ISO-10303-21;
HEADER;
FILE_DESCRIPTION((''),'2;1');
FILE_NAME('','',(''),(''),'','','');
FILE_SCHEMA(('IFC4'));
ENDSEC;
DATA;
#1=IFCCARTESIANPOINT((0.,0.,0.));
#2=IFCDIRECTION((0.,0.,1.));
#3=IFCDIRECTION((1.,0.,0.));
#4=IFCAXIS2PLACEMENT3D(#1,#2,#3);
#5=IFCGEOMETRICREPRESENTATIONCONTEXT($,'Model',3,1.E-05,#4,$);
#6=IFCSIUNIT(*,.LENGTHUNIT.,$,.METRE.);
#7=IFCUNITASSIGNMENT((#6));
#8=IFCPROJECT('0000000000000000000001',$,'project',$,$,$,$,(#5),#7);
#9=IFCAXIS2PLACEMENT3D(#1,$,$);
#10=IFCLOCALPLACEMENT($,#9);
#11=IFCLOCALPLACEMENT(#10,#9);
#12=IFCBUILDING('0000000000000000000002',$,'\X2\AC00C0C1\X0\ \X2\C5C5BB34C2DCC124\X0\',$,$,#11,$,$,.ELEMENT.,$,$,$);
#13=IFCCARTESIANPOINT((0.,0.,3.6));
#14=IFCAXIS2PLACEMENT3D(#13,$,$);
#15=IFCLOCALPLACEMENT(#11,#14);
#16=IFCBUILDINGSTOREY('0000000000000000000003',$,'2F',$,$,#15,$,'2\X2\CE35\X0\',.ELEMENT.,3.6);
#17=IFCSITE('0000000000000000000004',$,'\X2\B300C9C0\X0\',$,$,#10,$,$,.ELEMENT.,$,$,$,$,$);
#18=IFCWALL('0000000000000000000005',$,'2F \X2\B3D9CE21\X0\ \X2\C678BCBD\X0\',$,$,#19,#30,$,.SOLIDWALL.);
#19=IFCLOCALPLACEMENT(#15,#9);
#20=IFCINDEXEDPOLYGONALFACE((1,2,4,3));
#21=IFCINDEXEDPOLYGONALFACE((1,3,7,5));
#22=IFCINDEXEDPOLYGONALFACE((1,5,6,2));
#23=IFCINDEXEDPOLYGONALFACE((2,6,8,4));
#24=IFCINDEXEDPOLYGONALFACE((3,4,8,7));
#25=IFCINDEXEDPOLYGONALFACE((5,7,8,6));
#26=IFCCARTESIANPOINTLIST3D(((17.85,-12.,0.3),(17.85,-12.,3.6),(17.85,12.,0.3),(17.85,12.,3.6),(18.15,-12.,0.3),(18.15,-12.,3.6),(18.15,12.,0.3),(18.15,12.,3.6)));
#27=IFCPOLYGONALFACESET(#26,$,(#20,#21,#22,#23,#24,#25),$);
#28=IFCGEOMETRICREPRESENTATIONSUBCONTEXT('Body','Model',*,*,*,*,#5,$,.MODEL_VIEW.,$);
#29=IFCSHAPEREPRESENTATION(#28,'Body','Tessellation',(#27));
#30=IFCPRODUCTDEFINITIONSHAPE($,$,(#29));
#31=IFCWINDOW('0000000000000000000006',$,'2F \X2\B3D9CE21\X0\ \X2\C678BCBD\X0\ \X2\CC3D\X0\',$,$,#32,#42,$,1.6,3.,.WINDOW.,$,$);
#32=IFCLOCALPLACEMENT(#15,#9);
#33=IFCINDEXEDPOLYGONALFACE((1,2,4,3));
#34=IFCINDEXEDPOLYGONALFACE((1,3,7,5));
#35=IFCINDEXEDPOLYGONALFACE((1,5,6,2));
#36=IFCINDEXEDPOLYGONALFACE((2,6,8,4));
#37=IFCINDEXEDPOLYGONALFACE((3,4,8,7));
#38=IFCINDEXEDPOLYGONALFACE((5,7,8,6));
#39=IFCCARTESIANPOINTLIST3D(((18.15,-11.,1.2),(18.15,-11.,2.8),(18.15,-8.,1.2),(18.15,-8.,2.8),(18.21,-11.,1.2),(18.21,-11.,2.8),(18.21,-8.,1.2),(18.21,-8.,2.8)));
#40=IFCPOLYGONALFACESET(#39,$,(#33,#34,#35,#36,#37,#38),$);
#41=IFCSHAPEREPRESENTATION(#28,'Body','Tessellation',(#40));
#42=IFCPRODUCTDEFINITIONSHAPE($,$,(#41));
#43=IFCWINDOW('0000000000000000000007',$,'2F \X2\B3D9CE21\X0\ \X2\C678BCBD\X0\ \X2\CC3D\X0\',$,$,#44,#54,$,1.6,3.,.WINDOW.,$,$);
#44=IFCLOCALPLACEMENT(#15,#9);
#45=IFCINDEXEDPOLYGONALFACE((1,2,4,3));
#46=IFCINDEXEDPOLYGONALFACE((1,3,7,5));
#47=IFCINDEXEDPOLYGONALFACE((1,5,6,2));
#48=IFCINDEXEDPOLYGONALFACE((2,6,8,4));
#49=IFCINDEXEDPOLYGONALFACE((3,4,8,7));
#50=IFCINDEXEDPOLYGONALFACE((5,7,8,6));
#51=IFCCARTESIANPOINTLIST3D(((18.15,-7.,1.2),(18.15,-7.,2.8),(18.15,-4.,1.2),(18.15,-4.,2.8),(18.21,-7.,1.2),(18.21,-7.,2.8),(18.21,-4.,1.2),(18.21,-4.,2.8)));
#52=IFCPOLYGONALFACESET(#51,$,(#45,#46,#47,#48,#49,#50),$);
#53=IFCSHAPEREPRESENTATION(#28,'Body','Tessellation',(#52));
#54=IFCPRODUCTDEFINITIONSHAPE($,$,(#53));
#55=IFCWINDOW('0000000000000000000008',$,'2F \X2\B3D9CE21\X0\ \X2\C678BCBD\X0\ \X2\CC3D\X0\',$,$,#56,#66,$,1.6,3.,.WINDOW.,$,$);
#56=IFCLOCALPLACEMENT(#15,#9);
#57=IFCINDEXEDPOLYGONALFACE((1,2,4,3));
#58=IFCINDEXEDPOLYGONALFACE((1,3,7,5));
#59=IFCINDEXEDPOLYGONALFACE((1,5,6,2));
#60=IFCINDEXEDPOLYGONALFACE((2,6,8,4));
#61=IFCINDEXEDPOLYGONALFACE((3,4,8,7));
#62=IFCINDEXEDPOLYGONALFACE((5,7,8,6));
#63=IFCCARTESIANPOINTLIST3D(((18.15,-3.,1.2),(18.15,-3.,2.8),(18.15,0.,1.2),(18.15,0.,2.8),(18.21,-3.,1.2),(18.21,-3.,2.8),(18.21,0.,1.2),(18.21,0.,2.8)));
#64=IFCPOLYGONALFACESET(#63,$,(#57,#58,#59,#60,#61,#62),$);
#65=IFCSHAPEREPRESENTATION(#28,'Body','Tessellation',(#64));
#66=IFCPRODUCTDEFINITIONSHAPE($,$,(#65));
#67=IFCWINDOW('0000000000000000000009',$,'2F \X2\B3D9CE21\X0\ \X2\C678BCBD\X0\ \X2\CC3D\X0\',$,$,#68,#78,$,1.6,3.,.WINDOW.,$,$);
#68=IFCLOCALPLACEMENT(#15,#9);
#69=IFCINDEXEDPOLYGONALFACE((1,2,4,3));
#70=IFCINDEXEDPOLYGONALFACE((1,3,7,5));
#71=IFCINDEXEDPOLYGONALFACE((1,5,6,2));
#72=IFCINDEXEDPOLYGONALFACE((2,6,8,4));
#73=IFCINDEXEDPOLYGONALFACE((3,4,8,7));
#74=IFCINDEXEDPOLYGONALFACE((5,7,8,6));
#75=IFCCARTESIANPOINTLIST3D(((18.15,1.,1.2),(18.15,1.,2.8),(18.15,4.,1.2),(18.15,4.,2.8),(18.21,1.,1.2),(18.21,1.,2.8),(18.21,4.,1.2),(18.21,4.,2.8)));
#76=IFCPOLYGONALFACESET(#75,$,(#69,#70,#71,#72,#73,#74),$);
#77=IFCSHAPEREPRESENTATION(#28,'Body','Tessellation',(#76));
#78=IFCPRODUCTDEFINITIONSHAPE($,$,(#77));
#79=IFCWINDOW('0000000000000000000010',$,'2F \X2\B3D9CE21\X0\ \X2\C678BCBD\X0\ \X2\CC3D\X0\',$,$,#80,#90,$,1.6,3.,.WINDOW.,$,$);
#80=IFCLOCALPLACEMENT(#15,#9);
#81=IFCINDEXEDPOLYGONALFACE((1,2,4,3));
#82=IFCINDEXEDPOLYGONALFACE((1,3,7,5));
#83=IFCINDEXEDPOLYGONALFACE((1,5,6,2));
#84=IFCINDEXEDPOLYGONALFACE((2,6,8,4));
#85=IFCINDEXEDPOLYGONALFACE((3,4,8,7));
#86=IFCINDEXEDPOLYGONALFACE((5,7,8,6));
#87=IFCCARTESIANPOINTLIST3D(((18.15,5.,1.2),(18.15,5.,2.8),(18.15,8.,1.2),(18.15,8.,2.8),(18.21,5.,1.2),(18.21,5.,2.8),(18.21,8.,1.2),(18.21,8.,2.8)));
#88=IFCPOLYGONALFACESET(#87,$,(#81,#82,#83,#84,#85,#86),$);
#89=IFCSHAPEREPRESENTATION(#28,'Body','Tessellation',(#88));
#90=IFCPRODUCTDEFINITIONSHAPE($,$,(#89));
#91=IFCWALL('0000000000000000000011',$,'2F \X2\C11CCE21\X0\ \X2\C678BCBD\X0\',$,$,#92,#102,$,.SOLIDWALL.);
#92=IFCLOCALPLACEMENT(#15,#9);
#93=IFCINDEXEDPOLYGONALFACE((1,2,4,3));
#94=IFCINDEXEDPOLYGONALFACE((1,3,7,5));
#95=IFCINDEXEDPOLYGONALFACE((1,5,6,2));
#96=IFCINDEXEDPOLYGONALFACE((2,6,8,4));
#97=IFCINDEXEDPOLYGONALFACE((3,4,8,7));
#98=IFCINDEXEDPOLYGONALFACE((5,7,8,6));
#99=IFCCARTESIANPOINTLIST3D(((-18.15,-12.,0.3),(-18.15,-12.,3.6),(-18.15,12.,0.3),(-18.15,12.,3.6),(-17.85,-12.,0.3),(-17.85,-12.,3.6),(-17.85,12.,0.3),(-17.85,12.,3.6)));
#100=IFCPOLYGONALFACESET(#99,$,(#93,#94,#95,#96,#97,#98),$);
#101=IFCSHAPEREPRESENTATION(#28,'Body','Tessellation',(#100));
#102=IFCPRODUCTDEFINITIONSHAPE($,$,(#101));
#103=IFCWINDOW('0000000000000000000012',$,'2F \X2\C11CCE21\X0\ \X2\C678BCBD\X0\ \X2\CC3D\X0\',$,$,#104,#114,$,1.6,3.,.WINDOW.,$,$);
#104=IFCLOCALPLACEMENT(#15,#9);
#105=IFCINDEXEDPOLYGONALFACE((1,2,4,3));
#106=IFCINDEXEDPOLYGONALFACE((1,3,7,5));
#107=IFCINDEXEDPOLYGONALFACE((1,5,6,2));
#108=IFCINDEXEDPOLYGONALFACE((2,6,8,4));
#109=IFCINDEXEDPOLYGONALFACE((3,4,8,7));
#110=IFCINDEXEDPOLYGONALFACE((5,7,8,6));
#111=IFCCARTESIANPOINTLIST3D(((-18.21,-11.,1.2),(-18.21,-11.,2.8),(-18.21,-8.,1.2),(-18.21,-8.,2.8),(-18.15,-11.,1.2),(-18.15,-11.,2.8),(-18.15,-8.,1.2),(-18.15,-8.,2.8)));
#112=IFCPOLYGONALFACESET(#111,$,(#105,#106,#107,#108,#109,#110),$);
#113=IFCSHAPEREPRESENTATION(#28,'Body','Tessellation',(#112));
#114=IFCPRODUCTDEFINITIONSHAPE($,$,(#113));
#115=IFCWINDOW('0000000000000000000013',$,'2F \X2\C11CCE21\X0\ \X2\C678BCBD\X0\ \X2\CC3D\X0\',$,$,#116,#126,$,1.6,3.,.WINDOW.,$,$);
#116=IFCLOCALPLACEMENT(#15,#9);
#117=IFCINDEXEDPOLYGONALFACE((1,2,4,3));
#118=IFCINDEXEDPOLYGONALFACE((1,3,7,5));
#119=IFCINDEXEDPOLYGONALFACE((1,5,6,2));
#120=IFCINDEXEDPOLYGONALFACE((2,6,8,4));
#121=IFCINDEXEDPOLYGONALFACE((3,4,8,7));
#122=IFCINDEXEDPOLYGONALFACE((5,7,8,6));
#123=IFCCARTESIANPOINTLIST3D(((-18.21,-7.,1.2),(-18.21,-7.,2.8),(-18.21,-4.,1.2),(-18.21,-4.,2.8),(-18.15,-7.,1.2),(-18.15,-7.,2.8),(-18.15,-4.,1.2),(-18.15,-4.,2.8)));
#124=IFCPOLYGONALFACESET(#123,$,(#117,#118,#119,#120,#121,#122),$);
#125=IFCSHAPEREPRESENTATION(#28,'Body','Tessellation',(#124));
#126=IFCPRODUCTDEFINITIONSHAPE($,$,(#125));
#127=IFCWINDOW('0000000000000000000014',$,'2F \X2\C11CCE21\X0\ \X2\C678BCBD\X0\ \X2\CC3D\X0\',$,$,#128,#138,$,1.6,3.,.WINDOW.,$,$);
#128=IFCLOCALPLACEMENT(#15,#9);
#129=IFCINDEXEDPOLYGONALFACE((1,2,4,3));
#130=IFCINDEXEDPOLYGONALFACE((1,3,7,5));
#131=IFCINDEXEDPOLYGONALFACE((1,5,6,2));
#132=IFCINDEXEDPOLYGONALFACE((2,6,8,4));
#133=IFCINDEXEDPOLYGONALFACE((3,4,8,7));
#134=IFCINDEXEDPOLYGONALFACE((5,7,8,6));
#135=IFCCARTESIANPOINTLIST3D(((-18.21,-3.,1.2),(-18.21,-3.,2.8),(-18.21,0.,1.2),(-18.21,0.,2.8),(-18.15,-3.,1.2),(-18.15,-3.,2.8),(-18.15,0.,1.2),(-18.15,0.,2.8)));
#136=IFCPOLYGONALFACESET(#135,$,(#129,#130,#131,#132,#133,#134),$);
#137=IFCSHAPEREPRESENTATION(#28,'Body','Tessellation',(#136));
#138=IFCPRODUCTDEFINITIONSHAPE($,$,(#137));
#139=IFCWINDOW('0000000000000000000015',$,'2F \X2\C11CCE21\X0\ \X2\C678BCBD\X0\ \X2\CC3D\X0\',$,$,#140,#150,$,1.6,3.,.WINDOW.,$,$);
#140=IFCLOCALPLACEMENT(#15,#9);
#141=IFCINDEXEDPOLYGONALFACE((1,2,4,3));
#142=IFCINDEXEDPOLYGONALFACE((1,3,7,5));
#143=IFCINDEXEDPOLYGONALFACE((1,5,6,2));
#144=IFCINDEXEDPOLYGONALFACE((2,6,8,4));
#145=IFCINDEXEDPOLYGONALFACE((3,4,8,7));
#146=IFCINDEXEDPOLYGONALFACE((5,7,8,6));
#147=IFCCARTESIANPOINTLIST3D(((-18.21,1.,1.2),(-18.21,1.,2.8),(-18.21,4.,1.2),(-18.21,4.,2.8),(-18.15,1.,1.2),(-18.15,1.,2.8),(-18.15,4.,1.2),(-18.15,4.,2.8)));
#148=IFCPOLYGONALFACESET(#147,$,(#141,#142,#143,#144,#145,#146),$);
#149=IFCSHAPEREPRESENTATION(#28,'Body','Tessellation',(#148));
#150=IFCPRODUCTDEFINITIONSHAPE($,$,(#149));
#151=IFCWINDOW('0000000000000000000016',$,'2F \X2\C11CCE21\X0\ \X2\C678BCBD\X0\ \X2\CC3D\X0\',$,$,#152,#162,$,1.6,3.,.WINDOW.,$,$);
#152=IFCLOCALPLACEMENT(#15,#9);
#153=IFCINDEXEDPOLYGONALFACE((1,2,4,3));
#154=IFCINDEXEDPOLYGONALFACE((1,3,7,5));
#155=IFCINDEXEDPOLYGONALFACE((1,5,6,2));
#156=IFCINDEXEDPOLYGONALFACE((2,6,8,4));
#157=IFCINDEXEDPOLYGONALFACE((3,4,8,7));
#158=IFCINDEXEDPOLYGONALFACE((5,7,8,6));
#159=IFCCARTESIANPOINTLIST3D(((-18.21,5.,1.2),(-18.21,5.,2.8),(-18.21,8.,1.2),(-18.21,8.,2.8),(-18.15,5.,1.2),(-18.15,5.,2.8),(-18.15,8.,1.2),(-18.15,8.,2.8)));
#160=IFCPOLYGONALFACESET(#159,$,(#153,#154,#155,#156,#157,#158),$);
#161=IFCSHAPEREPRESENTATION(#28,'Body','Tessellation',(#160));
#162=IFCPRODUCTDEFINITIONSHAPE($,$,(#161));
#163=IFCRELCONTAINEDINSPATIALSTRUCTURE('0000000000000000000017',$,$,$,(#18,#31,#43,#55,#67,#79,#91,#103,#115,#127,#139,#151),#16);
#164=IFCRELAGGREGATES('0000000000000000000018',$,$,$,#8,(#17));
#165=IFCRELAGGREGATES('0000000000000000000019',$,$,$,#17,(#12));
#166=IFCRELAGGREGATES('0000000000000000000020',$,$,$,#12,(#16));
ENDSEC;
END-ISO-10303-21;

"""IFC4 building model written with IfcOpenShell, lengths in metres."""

from ifc_helpers import new_model, si_unit, frame, origin, origin_with_axes, origin_2d, place, context, subcontext, project, spatial, rectangle, extrude, element, save


model = new_model("IFC4")

# Units and contexts
model_context = context("Model", 3, precision=1e-05, world=origin_with_axes())
body_context = subcontext(model_context, "Body", "Model", "MODEL_VIEW")
ifc_project = project(units=[si_unit("LENGTHUNIT", "METRE")], contexts=[model_context])

# Site, building, storey
site_placement = place(None, origin())
site = spatial("IfcSite", under=ifc_project, at=site_placement, Name="대지", CompositionType="ELEMENT")
building_placement = place(site_placement, origin())
building = spatial("IfcBuilding", under=site, at=building_placement, Name="가상 업무시설", CompositionType="ELEMENT")
storey_placement = place(building_placement, frame((0.0, 0.0, 3.6)))
storey = spatial("IfcBuildingStorey", under=building, at=storey_placement, Name="2F", LongName="2층", CompositionType="ELEMENT", Elevation=3.6)

# Wall
wall_1_placement = place(storey_placement, frame((18.0, 0.0, 0.3)))
element("IfcWall", 1, at=wall_1_placement, inside=storey, Name="2F 동측 외벽", PredefinedType="SOLIDWALL", context=body_context, shape_type="SweptSolid", body=[
    extrude(rectangle(XDim=0.3, YDim=24.0, at=origin_2d()), origin_with_axes(), (0.0, 0.0, 1.0), 3.3),
])

# Windows
for number, where, name in (
    (2, (18.18, -9.5, 1.2), "2F 동측 외벽 창"),
    (3, (18.18, -5.5, 1.2), "2F 동측 외벽 창"),
    (4, (18.18, -1.5, 1.2), "2F 동측 외벽 창"),
    (5, (18.18, 2.5, 1.2), "2F 동측 외벽 창"),
    (6, (18.18, 6.5, 1.2), "2F 동측 외벽 창"),
):
    element("IfcWindow", number, at=place(storey_placement, frame(where)), inside=storey, Name=name, OverallHeight=1.6, OverallWidth=3.0, PredefinedType="WINDOW", context=body_context, shape_type="SweptSolid", body=[
        extrude(rectangle(XDim=0.06, YDim=3.0, at=origin_2d()), origin_with_axes(), (0.0, 0.0, 1.0), 1.6),
    ])

# Wall
wall_2_placement = place(storey_placement, frame((-18.0, 0.0, 0.3)))
element("IfcWall", 7, at=wall_2_placement, inside=storey, Name="2F 서측 외벽", PredefinedType="SOLIDWALL", context=body_context, shape_type="SweptSolid", body=[
    extrude(rectangle(XDim=0.3, YDim=24.0, at=origin_2d()), origin_with_axes(), (0.0, 0.0, 1.0), 3.3),
])

# Windows
for number, where, name in (
    (8, (-18.18, -9.5, 1.2), "2F 서측 외벽 창"),
    (9, (-18.18, -5.5, 1.2), "2F 서측 외벽 창"),
    (10, (-18.18, -1.5, 1.2), "2F 서측 외벽 창"),
    (11, (-18.18, 2.5, 1.2), "2F 서측 외벽 창"),
    (12, (-18.18, 6.5, 1.2), "2F 서측 외벽 창"),
):
    element("IfcWindow", number, at=place(storey_placement, frame(where)), inside=storey, Name=name, OverallHeight=1.6, OverallWidth=3.0, PredefinedType="WINDOW", context=body_context, shape_type="SweptSolid", body=[
        extrude(rectangle(XDim=0.06, YDim=3.0, at=origin_2d()), origin_with_axes(), (0.0, 0.0, 1.0), 1.6),
    ])

save(model, "model.ifc")
